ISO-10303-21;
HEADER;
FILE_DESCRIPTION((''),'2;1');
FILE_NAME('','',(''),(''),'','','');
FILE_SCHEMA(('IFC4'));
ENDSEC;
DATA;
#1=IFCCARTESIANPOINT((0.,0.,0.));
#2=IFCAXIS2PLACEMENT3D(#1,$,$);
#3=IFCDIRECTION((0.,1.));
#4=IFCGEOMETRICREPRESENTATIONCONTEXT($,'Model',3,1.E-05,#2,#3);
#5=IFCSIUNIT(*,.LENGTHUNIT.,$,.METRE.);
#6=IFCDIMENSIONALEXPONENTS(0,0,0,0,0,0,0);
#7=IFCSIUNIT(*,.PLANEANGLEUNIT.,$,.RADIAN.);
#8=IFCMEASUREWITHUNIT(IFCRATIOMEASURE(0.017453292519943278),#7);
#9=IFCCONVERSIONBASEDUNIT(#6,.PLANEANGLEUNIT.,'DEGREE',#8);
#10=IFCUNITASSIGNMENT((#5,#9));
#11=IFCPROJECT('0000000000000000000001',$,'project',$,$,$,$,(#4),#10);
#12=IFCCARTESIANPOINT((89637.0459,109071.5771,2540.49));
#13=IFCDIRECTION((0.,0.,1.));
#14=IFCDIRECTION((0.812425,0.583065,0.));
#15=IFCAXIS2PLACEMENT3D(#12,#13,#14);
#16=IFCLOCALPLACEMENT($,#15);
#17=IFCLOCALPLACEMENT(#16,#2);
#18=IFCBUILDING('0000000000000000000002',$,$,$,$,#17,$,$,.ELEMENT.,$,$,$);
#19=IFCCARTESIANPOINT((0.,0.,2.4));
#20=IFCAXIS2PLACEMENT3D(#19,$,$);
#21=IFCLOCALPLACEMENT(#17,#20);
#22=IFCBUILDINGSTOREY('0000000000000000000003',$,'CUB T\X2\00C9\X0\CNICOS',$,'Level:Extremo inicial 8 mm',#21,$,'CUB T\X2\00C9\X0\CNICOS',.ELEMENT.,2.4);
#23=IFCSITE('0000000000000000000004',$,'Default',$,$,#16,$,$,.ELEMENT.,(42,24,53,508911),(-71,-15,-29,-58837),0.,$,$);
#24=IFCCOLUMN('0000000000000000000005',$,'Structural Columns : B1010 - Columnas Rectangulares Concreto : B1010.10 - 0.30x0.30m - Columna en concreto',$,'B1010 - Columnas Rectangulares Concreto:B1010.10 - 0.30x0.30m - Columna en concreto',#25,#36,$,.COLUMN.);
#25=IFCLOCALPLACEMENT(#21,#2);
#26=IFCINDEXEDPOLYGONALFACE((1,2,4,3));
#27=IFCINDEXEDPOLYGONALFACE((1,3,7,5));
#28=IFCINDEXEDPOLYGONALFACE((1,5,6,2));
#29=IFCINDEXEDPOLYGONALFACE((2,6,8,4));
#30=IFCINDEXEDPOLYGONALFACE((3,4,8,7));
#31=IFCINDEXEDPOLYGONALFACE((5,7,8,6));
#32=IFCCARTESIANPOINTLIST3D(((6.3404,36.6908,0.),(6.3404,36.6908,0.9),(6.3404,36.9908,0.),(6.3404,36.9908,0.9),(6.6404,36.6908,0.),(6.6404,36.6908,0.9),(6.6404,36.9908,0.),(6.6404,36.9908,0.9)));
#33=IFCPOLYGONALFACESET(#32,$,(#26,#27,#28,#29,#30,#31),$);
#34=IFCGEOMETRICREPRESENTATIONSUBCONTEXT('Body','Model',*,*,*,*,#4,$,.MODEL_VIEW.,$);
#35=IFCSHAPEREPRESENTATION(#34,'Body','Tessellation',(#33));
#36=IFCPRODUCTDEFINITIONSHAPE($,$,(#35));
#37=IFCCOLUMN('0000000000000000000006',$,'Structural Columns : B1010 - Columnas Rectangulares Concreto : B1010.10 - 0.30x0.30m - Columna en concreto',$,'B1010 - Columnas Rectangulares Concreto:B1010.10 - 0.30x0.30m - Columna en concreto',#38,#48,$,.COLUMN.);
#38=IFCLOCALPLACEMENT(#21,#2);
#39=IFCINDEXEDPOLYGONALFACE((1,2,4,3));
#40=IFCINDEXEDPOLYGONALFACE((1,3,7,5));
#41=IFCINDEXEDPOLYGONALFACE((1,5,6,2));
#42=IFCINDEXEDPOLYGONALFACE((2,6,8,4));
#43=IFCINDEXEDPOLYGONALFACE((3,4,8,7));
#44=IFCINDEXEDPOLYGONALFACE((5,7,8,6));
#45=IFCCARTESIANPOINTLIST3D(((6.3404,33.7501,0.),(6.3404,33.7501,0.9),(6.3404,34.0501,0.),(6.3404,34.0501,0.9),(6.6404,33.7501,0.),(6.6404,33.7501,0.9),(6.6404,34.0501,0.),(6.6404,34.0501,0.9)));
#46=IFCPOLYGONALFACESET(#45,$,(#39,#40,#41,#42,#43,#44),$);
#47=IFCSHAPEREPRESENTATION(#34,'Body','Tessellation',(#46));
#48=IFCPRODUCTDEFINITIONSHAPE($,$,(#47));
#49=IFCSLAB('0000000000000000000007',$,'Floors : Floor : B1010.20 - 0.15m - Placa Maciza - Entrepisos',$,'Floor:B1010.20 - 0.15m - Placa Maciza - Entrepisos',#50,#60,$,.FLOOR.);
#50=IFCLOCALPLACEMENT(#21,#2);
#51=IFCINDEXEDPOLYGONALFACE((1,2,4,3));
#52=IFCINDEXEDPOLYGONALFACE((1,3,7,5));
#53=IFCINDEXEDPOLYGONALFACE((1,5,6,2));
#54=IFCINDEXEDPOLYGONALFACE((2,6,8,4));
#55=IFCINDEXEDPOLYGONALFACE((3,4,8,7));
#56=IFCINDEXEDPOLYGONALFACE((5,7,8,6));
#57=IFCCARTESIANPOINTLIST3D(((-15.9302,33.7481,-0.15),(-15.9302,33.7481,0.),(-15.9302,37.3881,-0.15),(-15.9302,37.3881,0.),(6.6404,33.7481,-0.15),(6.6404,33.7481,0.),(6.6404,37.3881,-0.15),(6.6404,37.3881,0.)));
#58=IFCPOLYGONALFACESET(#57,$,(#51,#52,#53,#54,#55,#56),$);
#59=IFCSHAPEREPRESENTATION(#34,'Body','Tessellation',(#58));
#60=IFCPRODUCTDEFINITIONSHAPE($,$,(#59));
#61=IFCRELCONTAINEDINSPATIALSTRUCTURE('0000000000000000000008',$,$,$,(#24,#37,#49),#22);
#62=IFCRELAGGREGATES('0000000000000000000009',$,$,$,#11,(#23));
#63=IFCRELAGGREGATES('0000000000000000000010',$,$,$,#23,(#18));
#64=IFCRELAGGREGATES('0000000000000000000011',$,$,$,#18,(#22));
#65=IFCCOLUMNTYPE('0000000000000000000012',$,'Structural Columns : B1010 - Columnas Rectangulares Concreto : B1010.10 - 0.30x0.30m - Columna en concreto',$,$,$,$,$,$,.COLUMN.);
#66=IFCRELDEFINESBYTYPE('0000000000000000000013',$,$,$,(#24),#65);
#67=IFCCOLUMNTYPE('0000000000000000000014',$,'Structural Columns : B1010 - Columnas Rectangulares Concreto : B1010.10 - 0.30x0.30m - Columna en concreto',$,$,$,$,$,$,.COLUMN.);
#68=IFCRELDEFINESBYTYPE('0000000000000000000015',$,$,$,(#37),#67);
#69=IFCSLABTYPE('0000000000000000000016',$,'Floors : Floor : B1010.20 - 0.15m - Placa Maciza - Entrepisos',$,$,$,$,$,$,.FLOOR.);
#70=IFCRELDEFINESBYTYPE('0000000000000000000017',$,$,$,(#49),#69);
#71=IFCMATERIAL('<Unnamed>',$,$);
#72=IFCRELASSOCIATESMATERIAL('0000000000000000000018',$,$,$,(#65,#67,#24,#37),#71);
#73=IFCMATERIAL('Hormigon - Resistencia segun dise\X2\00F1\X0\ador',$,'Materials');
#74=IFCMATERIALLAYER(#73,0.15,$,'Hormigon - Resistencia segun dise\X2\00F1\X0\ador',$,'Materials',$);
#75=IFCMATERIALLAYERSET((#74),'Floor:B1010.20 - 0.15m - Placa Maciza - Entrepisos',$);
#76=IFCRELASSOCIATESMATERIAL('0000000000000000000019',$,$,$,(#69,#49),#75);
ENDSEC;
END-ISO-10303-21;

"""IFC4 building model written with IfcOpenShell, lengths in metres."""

from ifc_helpers import new_model, entity, si_unit, converted_unit, direction, frame, frame_2d, origin, origin_2d_with_axis, place, context, subcontext, project, spatial, polyline, segment, composite_curve, rectangle, outline, extrude, source, transform, mapped, material, layer, layer_set, layer_usage, material_profile, profile_set, profile_usage, type_object, type_shapes, element, save


model = new_model("IFC4")

# Units and contexts
model_context = context("Model", 3, precision=1e-05, world=origin(), true_north=direction((0.0, 1.0)))
body_context = subcontext(model_context, "Body", "Model", "MODEL_VIEW")
ifc_project = project(units=[si_unit("LENGTHUNIT", "METRE"), converted_unit("PLANEANGLEUNIT", "DEGREE", entity("IfcRatioMeasure", 0.017453292519943278), si_unit("PLANEANGLEUNIT", "RADIAN"), dimensions=[0, 0, 0, 0, 0, 0, 0])], contexts=[model_context])

# Site, building, storey
site_placement = place(None, frame((89637.0459, 109071.5771, 2540.49), z_axis=(0.0, 0.0, 1.0), x_axis=(0.812425, 0.583065, 0.0)))
site = spatial("IfcSite", under=ifc_project, at=site_placement, Name="Default", CompositionType="ELEMENT", RefLatitude=(42, 24, 53, 508911), RefLongitude=(-71, -15, -29, -58837), RefElevation=0.0)
building_placement = place(site_placement, origin())
building = spatial("IfcBuilding", under=site, at=building_placement, CompositionType="ELEMENT")
storey_placement = place(building_placement, frame((0.0, 0.0, 2.4)))
storey = spatial("IfcBuildingStorey", under=building, at=storey_placement, Name="CUB TÉCNICOS", ObjectType="Level:Extremo inicial 8 mm", LongName="CUB TÉCNICOS", CompositionType="ELEMENT", Elevation=2.4)

# Columns
ifc_material_1 = material(Name="<Unnamed>")
ifc_material_profile_1 = material_profile(ifc_material_1, outline(composite_curve([segment(polyline([(0.15, 0.15, 0.0), (0.15, -0.15, 0.0)]), True, "CONTINUOUS"), segment(polyline([(0.15, -0.15, 0.0), (-0.15, -0.15, 0.0)]), True, "CONTINUOUS"), segment(polyline([(-0.15, -0.15, 0.0), (-0.15, 0.15, 0.0)]), True, "CONTINUOUS"), segment(polyline([(-0.15, 0.15, 0.0), (0.15, 0.15, 0.0)]), True, "CONTINUOUS")], self_intersect=False), kind="CURVE"), Name="B1010.10 - 0.30x0.30m - Columna en concreto")
ifc_material_profile_2 = material_profile(ifc_material_1, outline(composite_curve([segment(polyline([(0.15, 0.15, 2.3), (-0.15, 0.15, 2.3)]), True, "CONTINUOUS"), segment(polyline([(-0.15, 0.15, 2.3), (-0.15, -0.15, 2.3)]), True, "CONTINUOUS"), segment(polyline([(-0.15, -0.15, 2.3), (0.15, -0.15, 2.3)]), True, "CONTINUOUS"), segment(polyline([(0.15, -0.15, 2.3), (0.15, 0.15, 2.3)]), True, "CONTINUOUS")], self_intersect=False), kind="CURVE"), Name="B1010.10 - 0.30x0.30m - Columna en concreto")
ifc_profile_set_1 = profile_set([ifc_material_profile_1, ifc_material_profile_2], Name="B1010.10 - 0.30x0.30m - Columna en concreto")
ifc_profile_usage_1 = profile_usage(ifc_profile_set_1)
column_type_1 = type_object("IfcColumnType", Name="Structural Columns : B1010 - Columnas Rectangulares Concreto : B1010.10 - 0.30x0.30m - Columna en concreto", PredefinedType="COLUMN", material=ifc_profile_set_1)
shared_shape_1 = source(origin(), body_context, "Body", "SweptSolid", [
    extrude(rectangle(XDim=0.3, YDim=0.3, at=frame_2d((0.0, 0.0), x_axis=(1.0, 0.0))), frame((6.4904, 36.8408, 2.4), z_axis=(0.0, 0.0, 1.0), x_axis=(0.0, -1.0, 0.0)), (0.0, 0.0, 1.0), 0.9),
])
type_shapes(column_type_1, [shared_shape_1])
column_1_placement = place(storey_placement, frame((0.0, 0.0, -2.4)))
element("IfcColumn", 1, at=column_1_placement, inside=storey, type_object=column_type_1, material=ifc_profile_usage_1, Name="Structural Columns : B1010 - Columnas Rectangulares Concreto : B1010.10 - 0.30x0.30m - Columna en concreto", ObjectType="B1010 - Columnas Rectangulares Concreto:B1010.10 - 0.30x0.30m - Columna en concreto", PredefinedType="COLUMN", context=body_context, shape_type="MappedRepresentation", body=[
    mapped(shared_shape_1, transform((0.0, 0.0, 0.0), scale=1.0)),
])
ifc_profile_usage_2 = profile_usage(ifc_profile_set_1)
column_type_2 = type_object("IfcColumnType", Name="Structural Columns : B1010 - Columnas Rectangulares Concreto : B1010.10 - 0.30x0.30m - Columna en concreto", PredefinedType="COLUMN", material=ifc_profile_set_1)
shared_shape_2 = source(origin(), body_context, "Body", "SweptSolid", [
    extrude(rectangle(XDim=0.3, YDim=0.3, at=frame_2d((0.0, 0.0), x_axis=(1.0, 0.0))), frame((6.4904, 33.9001, 2.4), z_axis=(0.0, 0.0, 1.0), x_axis=(0.0, -1.0, 0.0)), (0.0, 0.0, 1.0), 0.9),
])
type_shapes(column_type_2, [shared_shape_2])
column_2_placement = place(storey_placement, frame((0.0, 0.0, -2.4)))
element("IfcColumn", 2, at=column_2_placement, inside=storey, type_object=column_type_2, material=ifc_profile_usage_2, Name="Structural Columns : B1010 - Columnas Rectangulares Concreto : B1010.10 - 0.30x0.30m - Columna en concreto", ObjectType="B1010 - Columnas Rectangulares Concreto:B1010.10 - 0.30x0.30m - Columna en concreto", PredefinedType="COLUMN", context=body_context, shape_type="MappedRepresentation", body=[
    mapped(shared_shape_2, transform((0.0, 0.0, 0.0), scale=1.0)),
])

# Slab
ifc_material_2 = material(Name="Hormigon - Resistencia segun diseñador", Category="Materials")
ifc_layer = layer(ifc_material_2, 0.15, Name="Hormigon - Resistencia segun diseñador", Category="Materials")
ifc_layer_set = layer_set([ifc_layer], Name="Floor:B1010.20 - 0.15m - Placa Maciza - Entrepisos")
ifc_layer_usage = layer_usage(ifc_layer_set, "AXIS3", "POSITIVE", 0.0)
slab_type = type_object("IfcSlabType", Name="Floors : Floor : B1010.20 - 0.15m - Placa Maciza - Entrepisos", PredefinedType="FLOOR", material=ifc_layer_set)
slab_placement = place(storey_placement, origin())
element("IfcSlab", 3, at=slab_placement, inside=storey, type_object=slab_type, material=ifc_layer_usage, Name="Floors : Floor : B1010.20 - 0.15m - Placa Maciza - Entrepisos", ObjectType="Floor:B1010.20 - 0.15m - Placa Maciza - Entrepisos", PredefinedType="FLOOR", context=body_context, shape_type="SweptSolid", body=[
    extrude(rectangle(XDim=3.6399, YDim=22.5706, at=origin_2d_with_axis()), frame((-4.6449, 35.5681, 0.0), z_axis=(0.0, 0.0, -1.0), x_axis=(0.0, 1.0, 0.0)), (0.0, 0.0, 1.0), 0.15),
])

save(model, "model.ifc")
